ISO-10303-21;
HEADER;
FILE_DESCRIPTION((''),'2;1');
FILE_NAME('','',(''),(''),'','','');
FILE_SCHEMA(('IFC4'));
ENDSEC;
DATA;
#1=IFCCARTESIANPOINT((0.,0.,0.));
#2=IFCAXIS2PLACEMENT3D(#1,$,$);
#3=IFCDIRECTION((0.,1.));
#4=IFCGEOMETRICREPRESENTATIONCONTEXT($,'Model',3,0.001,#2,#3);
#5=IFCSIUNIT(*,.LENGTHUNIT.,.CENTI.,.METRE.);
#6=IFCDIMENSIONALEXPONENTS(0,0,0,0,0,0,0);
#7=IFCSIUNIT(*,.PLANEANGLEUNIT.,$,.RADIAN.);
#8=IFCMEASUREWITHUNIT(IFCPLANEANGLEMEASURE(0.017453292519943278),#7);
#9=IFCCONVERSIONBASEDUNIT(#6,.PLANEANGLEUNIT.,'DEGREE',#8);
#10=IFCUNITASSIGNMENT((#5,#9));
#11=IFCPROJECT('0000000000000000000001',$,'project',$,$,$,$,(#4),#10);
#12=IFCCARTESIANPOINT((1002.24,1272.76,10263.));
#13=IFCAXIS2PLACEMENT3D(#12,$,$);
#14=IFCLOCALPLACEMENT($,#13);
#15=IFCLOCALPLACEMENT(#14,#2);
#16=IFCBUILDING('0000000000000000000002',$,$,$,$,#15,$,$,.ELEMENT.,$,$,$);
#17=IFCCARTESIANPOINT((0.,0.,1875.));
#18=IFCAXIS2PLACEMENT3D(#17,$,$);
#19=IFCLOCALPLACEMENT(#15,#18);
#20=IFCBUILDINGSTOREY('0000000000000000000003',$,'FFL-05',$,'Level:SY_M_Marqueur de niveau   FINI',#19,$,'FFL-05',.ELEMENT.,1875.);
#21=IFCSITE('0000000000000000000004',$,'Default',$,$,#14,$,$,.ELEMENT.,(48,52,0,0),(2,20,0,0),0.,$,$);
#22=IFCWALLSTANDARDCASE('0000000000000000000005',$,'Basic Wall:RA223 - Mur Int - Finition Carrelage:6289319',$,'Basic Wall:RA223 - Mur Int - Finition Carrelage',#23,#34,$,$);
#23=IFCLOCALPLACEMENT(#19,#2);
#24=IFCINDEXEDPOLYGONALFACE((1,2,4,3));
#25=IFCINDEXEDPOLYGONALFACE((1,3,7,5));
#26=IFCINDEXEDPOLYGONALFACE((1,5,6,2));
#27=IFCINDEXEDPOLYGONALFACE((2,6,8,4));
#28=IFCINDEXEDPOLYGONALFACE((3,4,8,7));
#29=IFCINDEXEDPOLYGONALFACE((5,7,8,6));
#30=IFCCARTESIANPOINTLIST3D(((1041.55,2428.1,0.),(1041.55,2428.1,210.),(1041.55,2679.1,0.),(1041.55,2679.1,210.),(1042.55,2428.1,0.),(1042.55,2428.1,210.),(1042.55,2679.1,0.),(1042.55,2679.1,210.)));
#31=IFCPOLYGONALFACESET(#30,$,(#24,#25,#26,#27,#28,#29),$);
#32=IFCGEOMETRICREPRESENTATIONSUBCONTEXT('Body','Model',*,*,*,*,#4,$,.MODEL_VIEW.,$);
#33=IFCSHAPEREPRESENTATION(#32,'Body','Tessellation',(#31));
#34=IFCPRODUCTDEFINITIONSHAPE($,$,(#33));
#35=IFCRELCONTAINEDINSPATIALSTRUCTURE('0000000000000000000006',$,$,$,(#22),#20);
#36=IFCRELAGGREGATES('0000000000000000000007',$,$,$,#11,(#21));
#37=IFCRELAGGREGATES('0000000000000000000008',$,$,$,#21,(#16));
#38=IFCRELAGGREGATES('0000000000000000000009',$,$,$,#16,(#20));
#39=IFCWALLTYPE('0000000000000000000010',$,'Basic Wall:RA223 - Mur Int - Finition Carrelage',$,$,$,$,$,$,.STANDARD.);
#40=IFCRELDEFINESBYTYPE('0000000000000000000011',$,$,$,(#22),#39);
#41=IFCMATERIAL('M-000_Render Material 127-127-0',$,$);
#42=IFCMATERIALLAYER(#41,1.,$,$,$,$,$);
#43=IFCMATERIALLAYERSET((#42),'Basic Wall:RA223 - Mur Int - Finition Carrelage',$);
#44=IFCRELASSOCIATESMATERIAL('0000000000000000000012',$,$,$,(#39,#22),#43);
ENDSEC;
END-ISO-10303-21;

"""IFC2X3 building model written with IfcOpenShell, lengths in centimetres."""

from ifc_helpers import new_model, entity, si_unit, converted_unit, direction, frame, frame_2d, origin, place, context, subcontext, project, spatial, rectangle, extrude, material, layer, layer_set, layer_usage, type_object, element, save


model = new_model("IFC2X3")

# Units and contexts
model_context = context("Model", 3, precision=0.001, world=origin(), true_north=direction((0.0, 1.0)))
body_context = subcontext(model_context, "Body", "Model", "MODEL_VIEW")
ifc_project = project(units=[si_unit("LENGTHUNIT", "METRE", prefix="CENTI"), converted_unit("PLANEANGLEUNIT", "DEGREE", entity("IfcPlaneAngleMeasure", 0.017453292519943278), si_unit("PLANEANGLEUNIT", "RADIAN"), dimensions=[0, 0, 0, 0, 0, 0, 0])], contexts=[model_context])

# Site, building, storey
site_placement = place(None, frame((1002.24, 1272.76, 10263.0)))
site = spatial("IfcSite", under=ifc_project, at=site_placement, Name="Default", CompositionType="ELEMENT", RefLatitude=(48, 52, 0, 0), RefLongitude=(2, 20, 0, 0), RefElevation=0.0)
building_placement = place(site_placement, origin())
building = spatial("IfcBuilding", under=site, at=building_placement, CompositionType="ELEMENT")
storey_placement = place(building_placement, frame((0.0, 0.0, 1875.0)))
storey = spatial("IfcBuildingStorey", under=building, at=storey_placement, Name="FFL-05", ObjectType="Level:SY_M_Marqueur de niveau   FINI", LongName="FFL-05", CompositionType="ELEMENT", Elevation=1875.0)

# Shared definitions
ifc_material_1 = material(Name="M-000_Render Material 127-127-0")
ifc_layer_1 = layer(ifc_material_1, 1.0)
ifc_layer_set_1 = layer_set([ifc_layer_1], Name="Basic Wall:RA223 - Mur Int - Finition Carrelage")
wall_type_1 = type_object("IfcWallType", Name="Basic Wall:RA223 - Mur Int - Finition Carrelage", PredefinedType="STANDARD", material=ifc_layer_set_1)

# Wall
ifc_layer_usage_1 = layer_usage(ifc_layer_set_1, "AXIS2", "POSITIVE", -0.5)
wall_1_placement = place(storey_placement, frame((1042.05, 2679.1, 0.0), z_axis=(0.0, 0.0, 1.0), x_axis=(0.0, -1.0, 0.0)))
element("IfcWallStandardCase", 1, at=wall_1_placement, inside=storey, type_object=wall_type_1, material=ifc_layer_usage_1, Name="Basic Wall:RA223 - Mur Int - Finition Carrelage:6289319", ObjectType="Basic Wall:RA223 - Mur Int - Finition Carrelage", context=body_context, shape_type="SweptSolid", body=[
    extrude(rectangle(XDim=251.0, YDim=1.0, at=frame_2d((125.5, 0.0), x_axis=(-1.0, 0.0))), origin(), (0.0, 0.0, 1.0), 210.0),
])

save(model, "model.ifc")
